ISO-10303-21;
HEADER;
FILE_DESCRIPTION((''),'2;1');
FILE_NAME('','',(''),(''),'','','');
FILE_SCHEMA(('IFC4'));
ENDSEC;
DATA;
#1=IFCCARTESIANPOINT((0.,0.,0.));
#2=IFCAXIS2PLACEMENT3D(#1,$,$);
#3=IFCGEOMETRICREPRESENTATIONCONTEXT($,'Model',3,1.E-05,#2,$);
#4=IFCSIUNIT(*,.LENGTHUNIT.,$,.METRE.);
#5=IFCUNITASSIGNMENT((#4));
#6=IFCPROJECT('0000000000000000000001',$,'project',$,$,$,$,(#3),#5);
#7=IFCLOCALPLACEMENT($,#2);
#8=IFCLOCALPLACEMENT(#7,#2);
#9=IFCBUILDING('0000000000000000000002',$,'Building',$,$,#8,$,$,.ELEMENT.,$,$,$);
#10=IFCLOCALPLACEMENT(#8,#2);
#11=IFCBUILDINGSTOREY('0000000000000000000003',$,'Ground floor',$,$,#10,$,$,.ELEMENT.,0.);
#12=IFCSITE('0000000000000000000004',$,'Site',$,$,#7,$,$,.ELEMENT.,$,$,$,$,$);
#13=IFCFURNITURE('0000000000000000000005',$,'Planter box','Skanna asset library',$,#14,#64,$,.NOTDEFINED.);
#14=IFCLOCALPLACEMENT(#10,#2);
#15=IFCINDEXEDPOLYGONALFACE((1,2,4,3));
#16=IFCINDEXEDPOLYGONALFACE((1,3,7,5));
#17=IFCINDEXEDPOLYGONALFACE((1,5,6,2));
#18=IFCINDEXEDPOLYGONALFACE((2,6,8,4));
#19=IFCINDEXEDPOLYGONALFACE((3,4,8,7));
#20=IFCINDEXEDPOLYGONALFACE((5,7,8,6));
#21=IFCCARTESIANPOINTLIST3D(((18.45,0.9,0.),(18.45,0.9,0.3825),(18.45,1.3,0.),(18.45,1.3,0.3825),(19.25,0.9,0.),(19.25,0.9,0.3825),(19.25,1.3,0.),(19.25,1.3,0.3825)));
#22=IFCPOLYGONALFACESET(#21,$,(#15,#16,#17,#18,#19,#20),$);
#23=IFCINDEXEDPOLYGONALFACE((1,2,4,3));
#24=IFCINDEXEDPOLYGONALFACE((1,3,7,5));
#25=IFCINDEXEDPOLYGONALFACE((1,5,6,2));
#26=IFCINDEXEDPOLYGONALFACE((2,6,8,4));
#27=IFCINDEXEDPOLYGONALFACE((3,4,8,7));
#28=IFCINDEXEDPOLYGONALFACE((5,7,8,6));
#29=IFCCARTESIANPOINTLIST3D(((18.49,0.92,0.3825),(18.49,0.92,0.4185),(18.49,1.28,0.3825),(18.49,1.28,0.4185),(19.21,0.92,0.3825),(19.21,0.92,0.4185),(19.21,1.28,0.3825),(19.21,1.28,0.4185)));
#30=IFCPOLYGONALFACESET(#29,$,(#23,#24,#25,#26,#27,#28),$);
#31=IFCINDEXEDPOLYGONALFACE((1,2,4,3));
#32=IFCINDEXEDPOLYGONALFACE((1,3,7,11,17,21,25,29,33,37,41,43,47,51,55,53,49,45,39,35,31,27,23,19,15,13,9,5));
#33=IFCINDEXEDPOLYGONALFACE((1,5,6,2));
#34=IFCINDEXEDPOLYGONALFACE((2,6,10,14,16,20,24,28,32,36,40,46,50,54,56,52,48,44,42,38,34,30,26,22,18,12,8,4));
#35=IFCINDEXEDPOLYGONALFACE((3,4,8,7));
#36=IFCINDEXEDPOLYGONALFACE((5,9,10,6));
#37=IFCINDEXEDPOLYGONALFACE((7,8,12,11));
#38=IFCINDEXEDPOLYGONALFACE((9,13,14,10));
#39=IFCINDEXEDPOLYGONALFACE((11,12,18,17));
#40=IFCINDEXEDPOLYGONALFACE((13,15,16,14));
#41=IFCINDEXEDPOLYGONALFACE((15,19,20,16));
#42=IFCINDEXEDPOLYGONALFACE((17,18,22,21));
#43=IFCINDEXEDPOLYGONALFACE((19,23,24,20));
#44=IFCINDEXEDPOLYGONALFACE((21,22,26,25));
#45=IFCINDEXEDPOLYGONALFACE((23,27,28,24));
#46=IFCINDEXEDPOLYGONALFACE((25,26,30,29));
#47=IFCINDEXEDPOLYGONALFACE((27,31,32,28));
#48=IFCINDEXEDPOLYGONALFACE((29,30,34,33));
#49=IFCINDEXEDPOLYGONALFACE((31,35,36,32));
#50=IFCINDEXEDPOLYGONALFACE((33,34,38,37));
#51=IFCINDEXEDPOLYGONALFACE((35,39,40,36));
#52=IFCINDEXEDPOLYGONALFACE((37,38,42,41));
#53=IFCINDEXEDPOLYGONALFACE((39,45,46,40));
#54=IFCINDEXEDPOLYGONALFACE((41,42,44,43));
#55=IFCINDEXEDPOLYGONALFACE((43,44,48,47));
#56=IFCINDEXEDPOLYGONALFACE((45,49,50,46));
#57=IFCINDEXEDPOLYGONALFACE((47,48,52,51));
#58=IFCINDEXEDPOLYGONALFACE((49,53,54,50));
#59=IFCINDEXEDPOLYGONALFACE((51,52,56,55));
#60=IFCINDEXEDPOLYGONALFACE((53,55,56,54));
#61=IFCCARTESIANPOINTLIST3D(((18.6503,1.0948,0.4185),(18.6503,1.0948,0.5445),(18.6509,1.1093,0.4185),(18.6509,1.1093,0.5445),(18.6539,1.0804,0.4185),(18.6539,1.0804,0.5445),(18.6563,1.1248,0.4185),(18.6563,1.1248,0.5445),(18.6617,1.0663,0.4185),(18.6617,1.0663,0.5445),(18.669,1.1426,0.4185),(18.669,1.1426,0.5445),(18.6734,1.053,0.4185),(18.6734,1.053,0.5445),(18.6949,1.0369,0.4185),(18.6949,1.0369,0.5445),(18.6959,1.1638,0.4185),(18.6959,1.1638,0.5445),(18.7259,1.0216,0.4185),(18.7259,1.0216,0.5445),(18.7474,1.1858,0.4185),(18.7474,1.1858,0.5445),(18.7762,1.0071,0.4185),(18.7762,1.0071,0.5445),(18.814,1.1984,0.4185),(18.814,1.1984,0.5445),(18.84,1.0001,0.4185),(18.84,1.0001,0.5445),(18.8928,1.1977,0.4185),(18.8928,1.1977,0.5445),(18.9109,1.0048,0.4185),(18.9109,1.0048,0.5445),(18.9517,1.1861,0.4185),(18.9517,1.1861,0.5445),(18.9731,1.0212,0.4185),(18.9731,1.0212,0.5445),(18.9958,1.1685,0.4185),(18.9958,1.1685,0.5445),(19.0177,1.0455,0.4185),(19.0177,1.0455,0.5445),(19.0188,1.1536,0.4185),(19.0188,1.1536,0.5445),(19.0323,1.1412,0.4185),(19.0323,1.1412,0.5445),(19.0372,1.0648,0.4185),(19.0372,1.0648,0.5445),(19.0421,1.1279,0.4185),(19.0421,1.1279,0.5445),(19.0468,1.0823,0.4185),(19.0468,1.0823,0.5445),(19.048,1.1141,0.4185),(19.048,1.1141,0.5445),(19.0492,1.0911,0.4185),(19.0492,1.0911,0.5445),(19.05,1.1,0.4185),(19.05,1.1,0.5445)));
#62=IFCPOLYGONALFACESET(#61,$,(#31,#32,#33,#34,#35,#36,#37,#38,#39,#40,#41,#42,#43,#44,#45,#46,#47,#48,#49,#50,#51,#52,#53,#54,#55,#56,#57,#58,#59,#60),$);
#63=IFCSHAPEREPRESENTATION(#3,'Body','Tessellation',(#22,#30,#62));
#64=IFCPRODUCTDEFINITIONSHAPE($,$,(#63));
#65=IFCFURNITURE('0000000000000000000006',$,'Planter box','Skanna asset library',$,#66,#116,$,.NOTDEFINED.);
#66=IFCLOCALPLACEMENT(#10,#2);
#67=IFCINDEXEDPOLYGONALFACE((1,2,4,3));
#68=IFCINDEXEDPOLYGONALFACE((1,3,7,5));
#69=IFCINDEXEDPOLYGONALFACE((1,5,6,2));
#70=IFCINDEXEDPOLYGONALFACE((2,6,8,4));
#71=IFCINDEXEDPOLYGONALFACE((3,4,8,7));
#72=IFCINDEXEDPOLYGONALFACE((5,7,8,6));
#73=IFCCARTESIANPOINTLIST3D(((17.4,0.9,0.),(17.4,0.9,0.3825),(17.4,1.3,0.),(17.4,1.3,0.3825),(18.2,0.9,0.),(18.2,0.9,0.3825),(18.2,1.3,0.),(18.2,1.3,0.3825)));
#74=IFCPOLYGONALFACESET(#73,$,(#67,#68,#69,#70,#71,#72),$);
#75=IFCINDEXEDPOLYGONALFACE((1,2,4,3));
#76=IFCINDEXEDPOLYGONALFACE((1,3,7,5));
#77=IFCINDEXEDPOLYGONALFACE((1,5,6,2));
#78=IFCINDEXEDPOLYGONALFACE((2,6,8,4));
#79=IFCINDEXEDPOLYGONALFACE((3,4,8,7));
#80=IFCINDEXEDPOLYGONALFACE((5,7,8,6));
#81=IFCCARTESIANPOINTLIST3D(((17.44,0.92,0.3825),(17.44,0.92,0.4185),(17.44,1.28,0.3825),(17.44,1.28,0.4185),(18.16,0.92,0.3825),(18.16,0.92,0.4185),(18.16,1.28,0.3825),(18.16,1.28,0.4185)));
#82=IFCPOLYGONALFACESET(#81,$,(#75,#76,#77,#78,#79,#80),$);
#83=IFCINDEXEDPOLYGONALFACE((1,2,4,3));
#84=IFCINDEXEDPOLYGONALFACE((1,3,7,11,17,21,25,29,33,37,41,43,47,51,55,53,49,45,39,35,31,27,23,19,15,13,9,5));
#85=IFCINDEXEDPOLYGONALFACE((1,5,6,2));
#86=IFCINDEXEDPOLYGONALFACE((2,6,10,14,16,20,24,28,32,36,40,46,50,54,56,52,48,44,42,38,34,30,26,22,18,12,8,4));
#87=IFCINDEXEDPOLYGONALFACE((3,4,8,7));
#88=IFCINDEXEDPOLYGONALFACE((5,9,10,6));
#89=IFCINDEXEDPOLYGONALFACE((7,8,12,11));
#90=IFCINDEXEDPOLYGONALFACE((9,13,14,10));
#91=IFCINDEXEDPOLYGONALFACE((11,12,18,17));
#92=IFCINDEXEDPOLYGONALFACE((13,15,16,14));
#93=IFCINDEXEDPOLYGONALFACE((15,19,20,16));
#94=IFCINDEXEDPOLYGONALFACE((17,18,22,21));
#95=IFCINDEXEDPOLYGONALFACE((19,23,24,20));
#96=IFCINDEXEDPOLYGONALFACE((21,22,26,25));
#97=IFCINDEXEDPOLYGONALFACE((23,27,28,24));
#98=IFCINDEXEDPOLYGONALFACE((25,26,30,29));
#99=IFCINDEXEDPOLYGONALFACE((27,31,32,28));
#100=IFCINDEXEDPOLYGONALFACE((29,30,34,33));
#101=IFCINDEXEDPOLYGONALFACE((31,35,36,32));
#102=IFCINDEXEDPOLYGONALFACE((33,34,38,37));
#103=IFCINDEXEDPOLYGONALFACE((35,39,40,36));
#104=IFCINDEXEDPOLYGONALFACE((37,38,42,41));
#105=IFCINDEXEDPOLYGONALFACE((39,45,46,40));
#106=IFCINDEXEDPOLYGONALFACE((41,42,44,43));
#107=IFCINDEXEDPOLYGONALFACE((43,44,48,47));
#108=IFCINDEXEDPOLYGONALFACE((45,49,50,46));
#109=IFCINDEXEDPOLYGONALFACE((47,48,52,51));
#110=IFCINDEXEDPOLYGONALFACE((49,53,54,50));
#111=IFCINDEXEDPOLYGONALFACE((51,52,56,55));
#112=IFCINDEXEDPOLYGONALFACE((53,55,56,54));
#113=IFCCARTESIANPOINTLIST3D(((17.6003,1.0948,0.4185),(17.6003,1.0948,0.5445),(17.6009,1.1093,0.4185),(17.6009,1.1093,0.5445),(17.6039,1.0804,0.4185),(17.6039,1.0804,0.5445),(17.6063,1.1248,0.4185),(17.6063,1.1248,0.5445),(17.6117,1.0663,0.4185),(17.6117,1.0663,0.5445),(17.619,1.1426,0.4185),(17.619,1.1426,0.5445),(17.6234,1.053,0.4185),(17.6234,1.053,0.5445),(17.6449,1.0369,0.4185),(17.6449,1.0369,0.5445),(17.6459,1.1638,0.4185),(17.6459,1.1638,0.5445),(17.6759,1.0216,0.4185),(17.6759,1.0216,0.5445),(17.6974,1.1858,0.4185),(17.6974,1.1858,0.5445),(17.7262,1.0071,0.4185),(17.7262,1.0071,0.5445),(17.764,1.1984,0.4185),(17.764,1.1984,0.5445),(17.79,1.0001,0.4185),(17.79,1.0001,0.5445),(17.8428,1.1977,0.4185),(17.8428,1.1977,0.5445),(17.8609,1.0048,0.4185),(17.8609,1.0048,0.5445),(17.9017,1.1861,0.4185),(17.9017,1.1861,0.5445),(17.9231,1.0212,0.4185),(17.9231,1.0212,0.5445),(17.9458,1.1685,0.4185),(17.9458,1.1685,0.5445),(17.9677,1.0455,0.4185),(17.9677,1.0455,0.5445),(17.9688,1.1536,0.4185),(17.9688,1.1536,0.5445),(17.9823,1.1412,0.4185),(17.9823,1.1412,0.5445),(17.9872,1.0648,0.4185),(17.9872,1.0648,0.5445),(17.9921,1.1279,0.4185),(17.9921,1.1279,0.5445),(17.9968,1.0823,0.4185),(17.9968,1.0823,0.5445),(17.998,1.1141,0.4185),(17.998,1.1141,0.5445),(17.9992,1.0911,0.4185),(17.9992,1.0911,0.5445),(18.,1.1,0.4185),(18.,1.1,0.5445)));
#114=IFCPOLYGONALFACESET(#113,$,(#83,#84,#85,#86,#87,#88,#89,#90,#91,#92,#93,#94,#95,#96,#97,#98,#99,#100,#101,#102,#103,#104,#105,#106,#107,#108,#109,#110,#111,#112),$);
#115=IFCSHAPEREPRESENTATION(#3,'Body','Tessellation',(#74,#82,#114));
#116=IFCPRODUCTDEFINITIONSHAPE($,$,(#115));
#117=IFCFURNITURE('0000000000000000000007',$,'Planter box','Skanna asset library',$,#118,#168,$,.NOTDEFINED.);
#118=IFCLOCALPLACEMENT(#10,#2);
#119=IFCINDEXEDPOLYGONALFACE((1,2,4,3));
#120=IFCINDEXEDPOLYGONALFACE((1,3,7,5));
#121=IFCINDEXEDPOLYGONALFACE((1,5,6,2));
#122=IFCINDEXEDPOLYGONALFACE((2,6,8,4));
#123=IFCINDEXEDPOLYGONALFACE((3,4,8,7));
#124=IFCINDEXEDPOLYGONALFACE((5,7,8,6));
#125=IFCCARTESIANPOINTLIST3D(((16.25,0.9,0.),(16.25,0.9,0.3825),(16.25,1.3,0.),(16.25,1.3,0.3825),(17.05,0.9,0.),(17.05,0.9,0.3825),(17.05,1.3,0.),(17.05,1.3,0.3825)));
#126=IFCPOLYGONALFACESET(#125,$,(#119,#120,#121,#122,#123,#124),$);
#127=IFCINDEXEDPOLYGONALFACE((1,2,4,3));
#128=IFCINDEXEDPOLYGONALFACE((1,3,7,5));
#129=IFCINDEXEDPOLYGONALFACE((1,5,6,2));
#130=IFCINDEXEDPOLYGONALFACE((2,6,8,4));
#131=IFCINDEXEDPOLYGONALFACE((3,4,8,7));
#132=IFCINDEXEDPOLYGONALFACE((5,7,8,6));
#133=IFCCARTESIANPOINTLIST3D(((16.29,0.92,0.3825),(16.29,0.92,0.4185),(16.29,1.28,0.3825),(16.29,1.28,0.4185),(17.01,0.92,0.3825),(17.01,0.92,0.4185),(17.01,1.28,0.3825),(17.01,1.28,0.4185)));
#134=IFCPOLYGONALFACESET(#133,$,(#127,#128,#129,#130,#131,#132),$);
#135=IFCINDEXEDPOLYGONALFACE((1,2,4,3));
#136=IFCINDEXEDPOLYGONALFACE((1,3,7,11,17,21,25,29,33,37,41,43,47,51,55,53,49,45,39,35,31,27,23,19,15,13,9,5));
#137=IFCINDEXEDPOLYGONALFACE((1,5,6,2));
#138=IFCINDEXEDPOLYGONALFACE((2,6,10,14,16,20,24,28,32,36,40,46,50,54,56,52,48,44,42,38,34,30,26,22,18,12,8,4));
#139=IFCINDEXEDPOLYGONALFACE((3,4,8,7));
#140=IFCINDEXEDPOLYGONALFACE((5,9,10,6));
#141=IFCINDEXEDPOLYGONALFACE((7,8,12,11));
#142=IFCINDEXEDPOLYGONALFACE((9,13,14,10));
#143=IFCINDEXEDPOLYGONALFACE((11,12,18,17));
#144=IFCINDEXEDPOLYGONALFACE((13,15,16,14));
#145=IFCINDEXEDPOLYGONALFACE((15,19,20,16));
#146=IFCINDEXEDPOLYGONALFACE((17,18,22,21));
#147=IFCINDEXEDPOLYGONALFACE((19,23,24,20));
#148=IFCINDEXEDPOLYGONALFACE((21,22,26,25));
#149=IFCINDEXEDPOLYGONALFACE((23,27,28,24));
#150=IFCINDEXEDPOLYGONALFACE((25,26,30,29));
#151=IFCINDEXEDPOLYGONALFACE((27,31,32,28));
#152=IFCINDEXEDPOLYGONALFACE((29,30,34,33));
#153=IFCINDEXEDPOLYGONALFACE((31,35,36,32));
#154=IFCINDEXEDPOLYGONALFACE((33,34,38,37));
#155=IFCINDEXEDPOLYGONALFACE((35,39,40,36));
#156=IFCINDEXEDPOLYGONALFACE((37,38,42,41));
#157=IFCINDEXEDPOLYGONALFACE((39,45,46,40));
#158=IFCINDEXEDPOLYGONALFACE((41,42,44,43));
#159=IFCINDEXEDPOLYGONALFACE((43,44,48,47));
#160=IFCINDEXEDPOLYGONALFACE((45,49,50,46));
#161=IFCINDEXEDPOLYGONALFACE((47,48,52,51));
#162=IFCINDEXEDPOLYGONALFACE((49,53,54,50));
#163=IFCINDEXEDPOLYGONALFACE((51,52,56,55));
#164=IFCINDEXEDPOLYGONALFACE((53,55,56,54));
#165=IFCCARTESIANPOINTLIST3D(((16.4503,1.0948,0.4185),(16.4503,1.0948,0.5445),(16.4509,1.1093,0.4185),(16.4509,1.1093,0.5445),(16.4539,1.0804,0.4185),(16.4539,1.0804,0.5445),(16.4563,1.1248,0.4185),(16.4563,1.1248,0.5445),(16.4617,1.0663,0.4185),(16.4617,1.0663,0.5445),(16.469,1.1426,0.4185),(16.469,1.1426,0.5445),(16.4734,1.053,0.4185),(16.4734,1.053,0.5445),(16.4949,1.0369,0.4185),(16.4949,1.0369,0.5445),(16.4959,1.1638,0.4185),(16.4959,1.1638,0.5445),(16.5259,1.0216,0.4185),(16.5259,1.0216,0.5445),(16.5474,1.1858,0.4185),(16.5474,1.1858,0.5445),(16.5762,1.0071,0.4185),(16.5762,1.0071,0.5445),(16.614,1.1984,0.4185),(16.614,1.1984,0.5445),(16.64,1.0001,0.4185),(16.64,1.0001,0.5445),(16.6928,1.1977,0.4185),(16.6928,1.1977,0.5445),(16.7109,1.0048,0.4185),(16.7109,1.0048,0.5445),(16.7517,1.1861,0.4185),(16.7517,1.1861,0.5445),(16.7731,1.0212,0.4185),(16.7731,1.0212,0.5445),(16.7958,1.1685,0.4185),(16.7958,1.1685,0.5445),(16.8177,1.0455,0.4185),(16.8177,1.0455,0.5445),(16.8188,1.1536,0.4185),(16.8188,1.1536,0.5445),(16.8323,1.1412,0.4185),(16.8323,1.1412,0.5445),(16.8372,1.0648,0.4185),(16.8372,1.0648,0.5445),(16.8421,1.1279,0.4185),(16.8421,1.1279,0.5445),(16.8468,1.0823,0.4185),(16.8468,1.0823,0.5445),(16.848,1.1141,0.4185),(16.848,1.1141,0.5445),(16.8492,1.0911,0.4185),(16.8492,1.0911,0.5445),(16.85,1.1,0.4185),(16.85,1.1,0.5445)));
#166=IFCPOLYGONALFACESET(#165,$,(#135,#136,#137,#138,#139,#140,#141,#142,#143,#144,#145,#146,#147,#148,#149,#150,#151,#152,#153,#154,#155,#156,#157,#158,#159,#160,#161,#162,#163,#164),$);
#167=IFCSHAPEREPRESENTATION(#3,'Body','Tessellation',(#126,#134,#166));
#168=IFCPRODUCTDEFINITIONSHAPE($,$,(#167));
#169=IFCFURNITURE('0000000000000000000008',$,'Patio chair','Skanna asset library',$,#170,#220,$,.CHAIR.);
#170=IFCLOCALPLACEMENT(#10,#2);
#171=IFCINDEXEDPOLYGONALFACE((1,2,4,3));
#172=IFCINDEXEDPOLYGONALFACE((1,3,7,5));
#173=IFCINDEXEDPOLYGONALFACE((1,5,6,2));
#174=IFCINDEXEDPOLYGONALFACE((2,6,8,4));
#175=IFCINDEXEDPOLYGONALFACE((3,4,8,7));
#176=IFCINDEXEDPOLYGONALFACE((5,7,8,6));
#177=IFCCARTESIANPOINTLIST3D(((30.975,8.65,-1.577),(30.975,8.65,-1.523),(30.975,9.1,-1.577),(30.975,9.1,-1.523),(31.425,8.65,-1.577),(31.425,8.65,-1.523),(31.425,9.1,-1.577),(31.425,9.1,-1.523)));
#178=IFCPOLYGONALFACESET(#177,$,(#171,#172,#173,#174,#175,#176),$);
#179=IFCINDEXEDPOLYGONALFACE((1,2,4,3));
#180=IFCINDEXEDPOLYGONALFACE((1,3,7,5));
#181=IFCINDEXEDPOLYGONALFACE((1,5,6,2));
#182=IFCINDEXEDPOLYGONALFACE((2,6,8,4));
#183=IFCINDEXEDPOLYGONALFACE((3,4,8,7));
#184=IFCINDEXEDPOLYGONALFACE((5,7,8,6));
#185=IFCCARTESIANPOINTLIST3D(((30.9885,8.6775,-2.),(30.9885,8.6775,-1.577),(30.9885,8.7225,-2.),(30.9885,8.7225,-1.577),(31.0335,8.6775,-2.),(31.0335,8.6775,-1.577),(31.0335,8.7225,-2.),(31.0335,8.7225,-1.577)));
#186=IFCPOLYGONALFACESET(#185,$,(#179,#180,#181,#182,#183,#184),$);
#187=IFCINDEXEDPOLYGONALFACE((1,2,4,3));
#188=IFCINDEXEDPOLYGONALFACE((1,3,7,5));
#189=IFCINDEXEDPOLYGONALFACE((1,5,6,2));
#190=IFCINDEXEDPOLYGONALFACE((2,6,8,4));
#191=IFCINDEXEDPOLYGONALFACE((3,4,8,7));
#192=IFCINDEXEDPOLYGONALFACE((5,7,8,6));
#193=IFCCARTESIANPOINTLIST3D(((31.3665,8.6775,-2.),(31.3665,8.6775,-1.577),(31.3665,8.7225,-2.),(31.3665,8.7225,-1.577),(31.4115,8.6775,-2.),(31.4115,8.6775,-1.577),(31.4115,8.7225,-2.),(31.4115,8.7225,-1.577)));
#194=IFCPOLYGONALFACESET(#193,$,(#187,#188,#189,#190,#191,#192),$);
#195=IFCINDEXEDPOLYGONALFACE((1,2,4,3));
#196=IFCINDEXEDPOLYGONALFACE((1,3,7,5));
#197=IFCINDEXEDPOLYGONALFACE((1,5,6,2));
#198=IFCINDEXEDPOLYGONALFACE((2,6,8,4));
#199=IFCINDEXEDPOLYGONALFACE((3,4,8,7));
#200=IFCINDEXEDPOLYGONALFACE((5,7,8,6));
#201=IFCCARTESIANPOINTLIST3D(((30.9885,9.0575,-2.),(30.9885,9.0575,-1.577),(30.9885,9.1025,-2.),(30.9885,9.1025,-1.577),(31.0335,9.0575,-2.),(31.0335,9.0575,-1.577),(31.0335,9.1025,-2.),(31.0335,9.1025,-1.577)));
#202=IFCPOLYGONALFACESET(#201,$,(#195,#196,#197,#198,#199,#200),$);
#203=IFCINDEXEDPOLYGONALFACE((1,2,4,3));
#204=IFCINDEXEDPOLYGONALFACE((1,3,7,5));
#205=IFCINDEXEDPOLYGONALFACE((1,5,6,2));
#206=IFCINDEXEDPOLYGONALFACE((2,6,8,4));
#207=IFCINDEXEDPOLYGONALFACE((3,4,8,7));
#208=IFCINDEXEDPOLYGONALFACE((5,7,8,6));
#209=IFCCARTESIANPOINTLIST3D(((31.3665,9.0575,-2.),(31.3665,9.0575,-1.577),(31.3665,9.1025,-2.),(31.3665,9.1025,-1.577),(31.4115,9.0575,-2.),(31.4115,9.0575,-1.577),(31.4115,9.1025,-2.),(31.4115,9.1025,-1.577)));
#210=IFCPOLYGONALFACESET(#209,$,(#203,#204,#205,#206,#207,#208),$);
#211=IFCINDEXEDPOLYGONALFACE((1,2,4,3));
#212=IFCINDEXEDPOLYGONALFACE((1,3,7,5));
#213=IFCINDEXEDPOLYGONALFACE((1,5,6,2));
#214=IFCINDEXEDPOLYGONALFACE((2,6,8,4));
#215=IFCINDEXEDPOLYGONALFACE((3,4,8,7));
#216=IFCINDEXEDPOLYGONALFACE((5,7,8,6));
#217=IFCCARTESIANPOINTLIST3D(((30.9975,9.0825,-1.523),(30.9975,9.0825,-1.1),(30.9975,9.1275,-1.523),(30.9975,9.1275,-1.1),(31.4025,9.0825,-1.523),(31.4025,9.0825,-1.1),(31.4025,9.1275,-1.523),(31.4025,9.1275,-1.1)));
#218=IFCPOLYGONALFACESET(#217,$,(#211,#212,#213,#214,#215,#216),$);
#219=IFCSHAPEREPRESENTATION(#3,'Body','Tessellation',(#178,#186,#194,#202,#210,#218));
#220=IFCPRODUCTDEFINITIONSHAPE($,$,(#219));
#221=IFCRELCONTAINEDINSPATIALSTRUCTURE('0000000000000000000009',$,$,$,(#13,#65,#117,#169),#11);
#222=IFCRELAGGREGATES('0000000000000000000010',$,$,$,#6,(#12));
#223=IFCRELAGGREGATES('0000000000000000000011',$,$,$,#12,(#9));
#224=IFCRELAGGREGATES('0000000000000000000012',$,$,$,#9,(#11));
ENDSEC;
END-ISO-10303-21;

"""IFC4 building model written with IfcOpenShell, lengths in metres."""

from ifc_helpers import new_model, si_unit, frame, frame_2d, origin, origin_2d, place, context, project, spatial, rectangle, ellipse, extrude, element, save


model = new_model("IFC4")

# Units and contexts
model_context = context("Model", 3, precision=1e-05, world=origin())
ifc_project = project(units=[si_unit("LENGTHUNIT", "METRE")], contexts=[model_context])

# Site, building, storey
site_placement = place(None, origin())
site = spatial("IfcSite", under=ifc_project, at=site_placement, Name="Site", CompositionType="ELEMENT")
building_placement = place(site_placement, origin())
building = spatial("IfcBuilding", under=site, at=building_placement, Name="Building", CompositionType="ELEMENT")
storey_placement = place(building_placement, origin())
storey = spatial("IfcBuildingStorey", under=building, at=storey_placement, Name="Ground floor", CompositionType="ELEMENT", Elevation=0.0)

# Furniture
for number, where, z_axis, x_axis, name in (
    (1, (18.85, 1.1, 0.0), (0.0, 0.0, 1.0), (1.0, 0.0, 0.0), "Planter box"),
    (2, (17.8, 1.1, 0.0), (0.0, 0.0, 1.0), (1.0, 0.0, 0.0), "Planter box"),
    (3, (16.65, 1.1, 0.0), (0.0, 0.0, 1.0), (1.0, 0.0, 0.0), "Planter box"),
):
    element("IfcFurniture", number, at=place(storey_placement, frame(where, z_axis=z_axis, x_axis=x_axis)), inside=storey, Name=name, Description="Skanna asset library", PredefinedType="NOTDEFINED", context=model_context, shape_type="SweptSolid", body=[
        extrude(rectangle(XDim=0.8, YDim=0.4, at=origin_2d()), origin(), (0.0, 0.0, 1.0), 0.3825),
        extrude(rectangle(XDim=0.72, YDim=0.36, at=origin_2d()), frame((0.0, 0.0, 0.3825)), (0.0, 0.0, 1.0), 0.036),
        extrude(ellipse(SemiAxis1=0.2, SemiAxis2=0.1, at=origin_2d()), frame((0.0, 0.0, 0.4185)), (0.0, 0.0, 1.0), 0.126),
    ])
for number, where, z_axis, x_axis, name in (
    (4, (31.2, 8.9, -2.0), (0.0, 0.0, 1.0), (1.0, 0.0, 0.0), "Patio chair"),
):
    element("IfcFurniture", number, at=place(storey_placement, frame(where, z_axis=z_axis, x_axis=x_axis)), inside=storey, Name=name, Description="Skanna asset library", PredefinedType="CHAIR", context=model_context, shape_type="SweptSolid", body=[
        extrude(rectangle(XDim=0.45, YDim=0.45, at=frame_2d((0.0, -0.025))), frame((0.0, 0.0, 0.423)), (0.0, 0.0, 1.0), 0.054),
        extrude(rectangle(XDim=0.045, YDim=0.045, at=frame_2d((-0.189, -0.2))), origin(), (0.0, 0.0, 1.0), 0.423),
        extrude(rectangle(XDim=0.045, YDim=0.045, at=frame_2d((0.189, -0.2))), origin(), (0.0, 0.0, 1.0), 0.423),
        extrude(rectangle(XDim=0.045, YDim=0.045, at=frame_2d((-0.189, 0.18))), origin(), (0.0, 0.0, 1.0), 0.423),
        extrude(rectangle(XDim=0.045, YDim=0.045, at=frame_2d((0.189, 0.18))), origin(), (0.0, 0.0, 1.0), 0.423),
        extrude(rectangle(XDim=0.405, YDim=0.045, at=frame_2d((0.0, 0.205))), frame((0.0, 0.0, 0.477)), (0.0, 0.0, 1.0), 0.423),
    ])

save(model, "model.ifc")
